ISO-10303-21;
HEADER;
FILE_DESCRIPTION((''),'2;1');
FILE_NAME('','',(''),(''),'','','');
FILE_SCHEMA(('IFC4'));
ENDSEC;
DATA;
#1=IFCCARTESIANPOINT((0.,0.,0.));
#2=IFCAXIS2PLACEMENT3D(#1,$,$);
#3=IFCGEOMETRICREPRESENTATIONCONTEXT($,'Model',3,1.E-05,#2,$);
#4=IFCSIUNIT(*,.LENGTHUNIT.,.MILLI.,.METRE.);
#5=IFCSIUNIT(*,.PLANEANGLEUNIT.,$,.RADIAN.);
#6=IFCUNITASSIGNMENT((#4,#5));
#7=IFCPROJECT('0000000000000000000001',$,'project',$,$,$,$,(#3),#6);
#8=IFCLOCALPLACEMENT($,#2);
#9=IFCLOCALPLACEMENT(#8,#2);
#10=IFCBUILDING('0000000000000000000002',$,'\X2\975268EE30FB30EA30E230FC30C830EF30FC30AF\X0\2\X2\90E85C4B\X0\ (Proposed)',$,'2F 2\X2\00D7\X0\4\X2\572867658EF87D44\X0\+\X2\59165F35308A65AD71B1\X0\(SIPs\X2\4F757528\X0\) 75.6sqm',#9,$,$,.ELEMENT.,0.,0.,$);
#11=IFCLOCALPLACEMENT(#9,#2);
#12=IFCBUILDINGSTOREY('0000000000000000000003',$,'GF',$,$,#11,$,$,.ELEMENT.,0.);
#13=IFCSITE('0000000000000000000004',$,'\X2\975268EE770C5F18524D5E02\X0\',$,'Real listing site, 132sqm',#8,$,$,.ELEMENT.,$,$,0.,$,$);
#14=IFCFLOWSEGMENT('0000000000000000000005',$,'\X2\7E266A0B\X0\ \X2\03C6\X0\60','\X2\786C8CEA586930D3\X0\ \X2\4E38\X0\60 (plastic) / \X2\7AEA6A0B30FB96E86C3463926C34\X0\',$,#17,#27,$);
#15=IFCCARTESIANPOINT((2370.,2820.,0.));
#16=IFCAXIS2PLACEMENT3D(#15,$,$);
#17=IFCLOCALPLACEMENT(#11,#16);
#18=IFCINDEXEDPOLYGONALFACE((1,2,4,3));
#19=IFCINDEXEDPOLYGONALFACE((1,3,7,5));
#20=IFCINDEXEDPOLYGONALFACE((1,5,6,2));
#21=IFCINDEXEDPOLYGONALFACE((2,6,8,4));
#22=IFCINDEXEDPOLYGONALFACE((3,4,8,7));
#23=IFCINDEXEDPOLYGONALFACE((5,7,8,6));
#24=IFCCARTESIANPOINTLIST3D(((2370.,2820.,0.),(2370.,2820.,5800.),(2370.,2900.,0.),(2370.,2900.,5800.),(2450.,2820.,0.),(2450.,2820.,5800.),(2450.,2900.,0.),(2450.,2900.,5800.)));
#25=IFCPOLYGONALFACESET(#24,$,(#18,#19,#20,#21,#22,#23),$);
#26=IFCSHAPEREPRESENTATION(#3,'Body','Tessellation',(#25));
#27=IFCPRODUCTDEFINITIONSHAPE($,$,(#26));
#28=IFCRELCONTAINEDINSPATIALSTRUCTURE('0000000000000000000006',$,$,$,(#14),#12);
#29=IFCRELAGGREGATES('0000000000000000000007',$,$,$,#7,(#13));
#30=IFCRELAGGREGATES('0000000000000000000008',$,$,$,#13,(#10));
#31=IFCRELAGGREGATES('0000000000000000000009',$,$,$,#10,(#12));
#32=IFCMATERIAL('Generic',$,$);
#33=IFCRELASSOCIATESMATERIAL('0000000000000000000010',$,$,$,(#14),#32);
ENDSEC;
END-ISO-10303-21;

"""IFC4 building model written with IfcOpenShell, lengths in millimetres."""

from ifc_helpers import new_model, si_unit, frame, frame_2d, origin, place, context, project, spatial, rectangle, extrude, material, element, save


model = new_model("IFC4")

# Units and contexts
model_context = context("Model", 3, precision=1e-05, world=origin())
ifc_project = project(units=[si_unit("LENGTHUNIT", "METRE", prefix="MILLI"), si_unit("PLANEANGLEUNIT", "RADIAN")], contexts=[model_context])

# Site, building, storey
site_placement = place(None, origin())
site = spatial("IfcSite", under=ifc_project, at=site_placement, Name="青森県弘前市", ObjectType="Real listing site, 132sqm", CompositionType="ELEMENT", RefElevation=0.0)
building_placement = place(site_placement, origin())
building = spatial("IfcBuilding", under=site, at=building_placement, Name="青森・リモートワーク2部屋 (Proposed)", ObjectType="2F 2×4在来軸組+外張り断熱(SIPs併用) 75.6sqm", CompositionType="ELEMENT", ElevationOfRefHeight=0.0, ElevationOfTerrain=0.0)
storey_placement = place(building_placement, origin())
storey = spatial("IfcBuildingStorey", under=building, at=storey_placement, Name="GF", CompositionType="ELEMENT", Elevation=0.0)

# Flow segment
ifc_material_1 = material(Name="Generic")
flow_segment_1_placement = place(storey_placement, frame((2370.0, 2820.0, 0.0)))
element("IfcFlowSegment", 1, at=flow_segment_1_placement, inside=storey, material=ifc_material_1, Name="縦樋 φ60", Description="硬質塩ビ 丸60 (plastic) / 竪樋・雨水排水", context=model_context, shape_type="SweptSolid", body=[
    extrude(rectangle(XDim=80.0, YDim=80.0, at=frame_2d((40.0, 40.0))), frame((2370.0, 2820.0, 0.0)), (0.0, 0.0, 1.0), 5800.0),
])

save(model, "model.ifc")
